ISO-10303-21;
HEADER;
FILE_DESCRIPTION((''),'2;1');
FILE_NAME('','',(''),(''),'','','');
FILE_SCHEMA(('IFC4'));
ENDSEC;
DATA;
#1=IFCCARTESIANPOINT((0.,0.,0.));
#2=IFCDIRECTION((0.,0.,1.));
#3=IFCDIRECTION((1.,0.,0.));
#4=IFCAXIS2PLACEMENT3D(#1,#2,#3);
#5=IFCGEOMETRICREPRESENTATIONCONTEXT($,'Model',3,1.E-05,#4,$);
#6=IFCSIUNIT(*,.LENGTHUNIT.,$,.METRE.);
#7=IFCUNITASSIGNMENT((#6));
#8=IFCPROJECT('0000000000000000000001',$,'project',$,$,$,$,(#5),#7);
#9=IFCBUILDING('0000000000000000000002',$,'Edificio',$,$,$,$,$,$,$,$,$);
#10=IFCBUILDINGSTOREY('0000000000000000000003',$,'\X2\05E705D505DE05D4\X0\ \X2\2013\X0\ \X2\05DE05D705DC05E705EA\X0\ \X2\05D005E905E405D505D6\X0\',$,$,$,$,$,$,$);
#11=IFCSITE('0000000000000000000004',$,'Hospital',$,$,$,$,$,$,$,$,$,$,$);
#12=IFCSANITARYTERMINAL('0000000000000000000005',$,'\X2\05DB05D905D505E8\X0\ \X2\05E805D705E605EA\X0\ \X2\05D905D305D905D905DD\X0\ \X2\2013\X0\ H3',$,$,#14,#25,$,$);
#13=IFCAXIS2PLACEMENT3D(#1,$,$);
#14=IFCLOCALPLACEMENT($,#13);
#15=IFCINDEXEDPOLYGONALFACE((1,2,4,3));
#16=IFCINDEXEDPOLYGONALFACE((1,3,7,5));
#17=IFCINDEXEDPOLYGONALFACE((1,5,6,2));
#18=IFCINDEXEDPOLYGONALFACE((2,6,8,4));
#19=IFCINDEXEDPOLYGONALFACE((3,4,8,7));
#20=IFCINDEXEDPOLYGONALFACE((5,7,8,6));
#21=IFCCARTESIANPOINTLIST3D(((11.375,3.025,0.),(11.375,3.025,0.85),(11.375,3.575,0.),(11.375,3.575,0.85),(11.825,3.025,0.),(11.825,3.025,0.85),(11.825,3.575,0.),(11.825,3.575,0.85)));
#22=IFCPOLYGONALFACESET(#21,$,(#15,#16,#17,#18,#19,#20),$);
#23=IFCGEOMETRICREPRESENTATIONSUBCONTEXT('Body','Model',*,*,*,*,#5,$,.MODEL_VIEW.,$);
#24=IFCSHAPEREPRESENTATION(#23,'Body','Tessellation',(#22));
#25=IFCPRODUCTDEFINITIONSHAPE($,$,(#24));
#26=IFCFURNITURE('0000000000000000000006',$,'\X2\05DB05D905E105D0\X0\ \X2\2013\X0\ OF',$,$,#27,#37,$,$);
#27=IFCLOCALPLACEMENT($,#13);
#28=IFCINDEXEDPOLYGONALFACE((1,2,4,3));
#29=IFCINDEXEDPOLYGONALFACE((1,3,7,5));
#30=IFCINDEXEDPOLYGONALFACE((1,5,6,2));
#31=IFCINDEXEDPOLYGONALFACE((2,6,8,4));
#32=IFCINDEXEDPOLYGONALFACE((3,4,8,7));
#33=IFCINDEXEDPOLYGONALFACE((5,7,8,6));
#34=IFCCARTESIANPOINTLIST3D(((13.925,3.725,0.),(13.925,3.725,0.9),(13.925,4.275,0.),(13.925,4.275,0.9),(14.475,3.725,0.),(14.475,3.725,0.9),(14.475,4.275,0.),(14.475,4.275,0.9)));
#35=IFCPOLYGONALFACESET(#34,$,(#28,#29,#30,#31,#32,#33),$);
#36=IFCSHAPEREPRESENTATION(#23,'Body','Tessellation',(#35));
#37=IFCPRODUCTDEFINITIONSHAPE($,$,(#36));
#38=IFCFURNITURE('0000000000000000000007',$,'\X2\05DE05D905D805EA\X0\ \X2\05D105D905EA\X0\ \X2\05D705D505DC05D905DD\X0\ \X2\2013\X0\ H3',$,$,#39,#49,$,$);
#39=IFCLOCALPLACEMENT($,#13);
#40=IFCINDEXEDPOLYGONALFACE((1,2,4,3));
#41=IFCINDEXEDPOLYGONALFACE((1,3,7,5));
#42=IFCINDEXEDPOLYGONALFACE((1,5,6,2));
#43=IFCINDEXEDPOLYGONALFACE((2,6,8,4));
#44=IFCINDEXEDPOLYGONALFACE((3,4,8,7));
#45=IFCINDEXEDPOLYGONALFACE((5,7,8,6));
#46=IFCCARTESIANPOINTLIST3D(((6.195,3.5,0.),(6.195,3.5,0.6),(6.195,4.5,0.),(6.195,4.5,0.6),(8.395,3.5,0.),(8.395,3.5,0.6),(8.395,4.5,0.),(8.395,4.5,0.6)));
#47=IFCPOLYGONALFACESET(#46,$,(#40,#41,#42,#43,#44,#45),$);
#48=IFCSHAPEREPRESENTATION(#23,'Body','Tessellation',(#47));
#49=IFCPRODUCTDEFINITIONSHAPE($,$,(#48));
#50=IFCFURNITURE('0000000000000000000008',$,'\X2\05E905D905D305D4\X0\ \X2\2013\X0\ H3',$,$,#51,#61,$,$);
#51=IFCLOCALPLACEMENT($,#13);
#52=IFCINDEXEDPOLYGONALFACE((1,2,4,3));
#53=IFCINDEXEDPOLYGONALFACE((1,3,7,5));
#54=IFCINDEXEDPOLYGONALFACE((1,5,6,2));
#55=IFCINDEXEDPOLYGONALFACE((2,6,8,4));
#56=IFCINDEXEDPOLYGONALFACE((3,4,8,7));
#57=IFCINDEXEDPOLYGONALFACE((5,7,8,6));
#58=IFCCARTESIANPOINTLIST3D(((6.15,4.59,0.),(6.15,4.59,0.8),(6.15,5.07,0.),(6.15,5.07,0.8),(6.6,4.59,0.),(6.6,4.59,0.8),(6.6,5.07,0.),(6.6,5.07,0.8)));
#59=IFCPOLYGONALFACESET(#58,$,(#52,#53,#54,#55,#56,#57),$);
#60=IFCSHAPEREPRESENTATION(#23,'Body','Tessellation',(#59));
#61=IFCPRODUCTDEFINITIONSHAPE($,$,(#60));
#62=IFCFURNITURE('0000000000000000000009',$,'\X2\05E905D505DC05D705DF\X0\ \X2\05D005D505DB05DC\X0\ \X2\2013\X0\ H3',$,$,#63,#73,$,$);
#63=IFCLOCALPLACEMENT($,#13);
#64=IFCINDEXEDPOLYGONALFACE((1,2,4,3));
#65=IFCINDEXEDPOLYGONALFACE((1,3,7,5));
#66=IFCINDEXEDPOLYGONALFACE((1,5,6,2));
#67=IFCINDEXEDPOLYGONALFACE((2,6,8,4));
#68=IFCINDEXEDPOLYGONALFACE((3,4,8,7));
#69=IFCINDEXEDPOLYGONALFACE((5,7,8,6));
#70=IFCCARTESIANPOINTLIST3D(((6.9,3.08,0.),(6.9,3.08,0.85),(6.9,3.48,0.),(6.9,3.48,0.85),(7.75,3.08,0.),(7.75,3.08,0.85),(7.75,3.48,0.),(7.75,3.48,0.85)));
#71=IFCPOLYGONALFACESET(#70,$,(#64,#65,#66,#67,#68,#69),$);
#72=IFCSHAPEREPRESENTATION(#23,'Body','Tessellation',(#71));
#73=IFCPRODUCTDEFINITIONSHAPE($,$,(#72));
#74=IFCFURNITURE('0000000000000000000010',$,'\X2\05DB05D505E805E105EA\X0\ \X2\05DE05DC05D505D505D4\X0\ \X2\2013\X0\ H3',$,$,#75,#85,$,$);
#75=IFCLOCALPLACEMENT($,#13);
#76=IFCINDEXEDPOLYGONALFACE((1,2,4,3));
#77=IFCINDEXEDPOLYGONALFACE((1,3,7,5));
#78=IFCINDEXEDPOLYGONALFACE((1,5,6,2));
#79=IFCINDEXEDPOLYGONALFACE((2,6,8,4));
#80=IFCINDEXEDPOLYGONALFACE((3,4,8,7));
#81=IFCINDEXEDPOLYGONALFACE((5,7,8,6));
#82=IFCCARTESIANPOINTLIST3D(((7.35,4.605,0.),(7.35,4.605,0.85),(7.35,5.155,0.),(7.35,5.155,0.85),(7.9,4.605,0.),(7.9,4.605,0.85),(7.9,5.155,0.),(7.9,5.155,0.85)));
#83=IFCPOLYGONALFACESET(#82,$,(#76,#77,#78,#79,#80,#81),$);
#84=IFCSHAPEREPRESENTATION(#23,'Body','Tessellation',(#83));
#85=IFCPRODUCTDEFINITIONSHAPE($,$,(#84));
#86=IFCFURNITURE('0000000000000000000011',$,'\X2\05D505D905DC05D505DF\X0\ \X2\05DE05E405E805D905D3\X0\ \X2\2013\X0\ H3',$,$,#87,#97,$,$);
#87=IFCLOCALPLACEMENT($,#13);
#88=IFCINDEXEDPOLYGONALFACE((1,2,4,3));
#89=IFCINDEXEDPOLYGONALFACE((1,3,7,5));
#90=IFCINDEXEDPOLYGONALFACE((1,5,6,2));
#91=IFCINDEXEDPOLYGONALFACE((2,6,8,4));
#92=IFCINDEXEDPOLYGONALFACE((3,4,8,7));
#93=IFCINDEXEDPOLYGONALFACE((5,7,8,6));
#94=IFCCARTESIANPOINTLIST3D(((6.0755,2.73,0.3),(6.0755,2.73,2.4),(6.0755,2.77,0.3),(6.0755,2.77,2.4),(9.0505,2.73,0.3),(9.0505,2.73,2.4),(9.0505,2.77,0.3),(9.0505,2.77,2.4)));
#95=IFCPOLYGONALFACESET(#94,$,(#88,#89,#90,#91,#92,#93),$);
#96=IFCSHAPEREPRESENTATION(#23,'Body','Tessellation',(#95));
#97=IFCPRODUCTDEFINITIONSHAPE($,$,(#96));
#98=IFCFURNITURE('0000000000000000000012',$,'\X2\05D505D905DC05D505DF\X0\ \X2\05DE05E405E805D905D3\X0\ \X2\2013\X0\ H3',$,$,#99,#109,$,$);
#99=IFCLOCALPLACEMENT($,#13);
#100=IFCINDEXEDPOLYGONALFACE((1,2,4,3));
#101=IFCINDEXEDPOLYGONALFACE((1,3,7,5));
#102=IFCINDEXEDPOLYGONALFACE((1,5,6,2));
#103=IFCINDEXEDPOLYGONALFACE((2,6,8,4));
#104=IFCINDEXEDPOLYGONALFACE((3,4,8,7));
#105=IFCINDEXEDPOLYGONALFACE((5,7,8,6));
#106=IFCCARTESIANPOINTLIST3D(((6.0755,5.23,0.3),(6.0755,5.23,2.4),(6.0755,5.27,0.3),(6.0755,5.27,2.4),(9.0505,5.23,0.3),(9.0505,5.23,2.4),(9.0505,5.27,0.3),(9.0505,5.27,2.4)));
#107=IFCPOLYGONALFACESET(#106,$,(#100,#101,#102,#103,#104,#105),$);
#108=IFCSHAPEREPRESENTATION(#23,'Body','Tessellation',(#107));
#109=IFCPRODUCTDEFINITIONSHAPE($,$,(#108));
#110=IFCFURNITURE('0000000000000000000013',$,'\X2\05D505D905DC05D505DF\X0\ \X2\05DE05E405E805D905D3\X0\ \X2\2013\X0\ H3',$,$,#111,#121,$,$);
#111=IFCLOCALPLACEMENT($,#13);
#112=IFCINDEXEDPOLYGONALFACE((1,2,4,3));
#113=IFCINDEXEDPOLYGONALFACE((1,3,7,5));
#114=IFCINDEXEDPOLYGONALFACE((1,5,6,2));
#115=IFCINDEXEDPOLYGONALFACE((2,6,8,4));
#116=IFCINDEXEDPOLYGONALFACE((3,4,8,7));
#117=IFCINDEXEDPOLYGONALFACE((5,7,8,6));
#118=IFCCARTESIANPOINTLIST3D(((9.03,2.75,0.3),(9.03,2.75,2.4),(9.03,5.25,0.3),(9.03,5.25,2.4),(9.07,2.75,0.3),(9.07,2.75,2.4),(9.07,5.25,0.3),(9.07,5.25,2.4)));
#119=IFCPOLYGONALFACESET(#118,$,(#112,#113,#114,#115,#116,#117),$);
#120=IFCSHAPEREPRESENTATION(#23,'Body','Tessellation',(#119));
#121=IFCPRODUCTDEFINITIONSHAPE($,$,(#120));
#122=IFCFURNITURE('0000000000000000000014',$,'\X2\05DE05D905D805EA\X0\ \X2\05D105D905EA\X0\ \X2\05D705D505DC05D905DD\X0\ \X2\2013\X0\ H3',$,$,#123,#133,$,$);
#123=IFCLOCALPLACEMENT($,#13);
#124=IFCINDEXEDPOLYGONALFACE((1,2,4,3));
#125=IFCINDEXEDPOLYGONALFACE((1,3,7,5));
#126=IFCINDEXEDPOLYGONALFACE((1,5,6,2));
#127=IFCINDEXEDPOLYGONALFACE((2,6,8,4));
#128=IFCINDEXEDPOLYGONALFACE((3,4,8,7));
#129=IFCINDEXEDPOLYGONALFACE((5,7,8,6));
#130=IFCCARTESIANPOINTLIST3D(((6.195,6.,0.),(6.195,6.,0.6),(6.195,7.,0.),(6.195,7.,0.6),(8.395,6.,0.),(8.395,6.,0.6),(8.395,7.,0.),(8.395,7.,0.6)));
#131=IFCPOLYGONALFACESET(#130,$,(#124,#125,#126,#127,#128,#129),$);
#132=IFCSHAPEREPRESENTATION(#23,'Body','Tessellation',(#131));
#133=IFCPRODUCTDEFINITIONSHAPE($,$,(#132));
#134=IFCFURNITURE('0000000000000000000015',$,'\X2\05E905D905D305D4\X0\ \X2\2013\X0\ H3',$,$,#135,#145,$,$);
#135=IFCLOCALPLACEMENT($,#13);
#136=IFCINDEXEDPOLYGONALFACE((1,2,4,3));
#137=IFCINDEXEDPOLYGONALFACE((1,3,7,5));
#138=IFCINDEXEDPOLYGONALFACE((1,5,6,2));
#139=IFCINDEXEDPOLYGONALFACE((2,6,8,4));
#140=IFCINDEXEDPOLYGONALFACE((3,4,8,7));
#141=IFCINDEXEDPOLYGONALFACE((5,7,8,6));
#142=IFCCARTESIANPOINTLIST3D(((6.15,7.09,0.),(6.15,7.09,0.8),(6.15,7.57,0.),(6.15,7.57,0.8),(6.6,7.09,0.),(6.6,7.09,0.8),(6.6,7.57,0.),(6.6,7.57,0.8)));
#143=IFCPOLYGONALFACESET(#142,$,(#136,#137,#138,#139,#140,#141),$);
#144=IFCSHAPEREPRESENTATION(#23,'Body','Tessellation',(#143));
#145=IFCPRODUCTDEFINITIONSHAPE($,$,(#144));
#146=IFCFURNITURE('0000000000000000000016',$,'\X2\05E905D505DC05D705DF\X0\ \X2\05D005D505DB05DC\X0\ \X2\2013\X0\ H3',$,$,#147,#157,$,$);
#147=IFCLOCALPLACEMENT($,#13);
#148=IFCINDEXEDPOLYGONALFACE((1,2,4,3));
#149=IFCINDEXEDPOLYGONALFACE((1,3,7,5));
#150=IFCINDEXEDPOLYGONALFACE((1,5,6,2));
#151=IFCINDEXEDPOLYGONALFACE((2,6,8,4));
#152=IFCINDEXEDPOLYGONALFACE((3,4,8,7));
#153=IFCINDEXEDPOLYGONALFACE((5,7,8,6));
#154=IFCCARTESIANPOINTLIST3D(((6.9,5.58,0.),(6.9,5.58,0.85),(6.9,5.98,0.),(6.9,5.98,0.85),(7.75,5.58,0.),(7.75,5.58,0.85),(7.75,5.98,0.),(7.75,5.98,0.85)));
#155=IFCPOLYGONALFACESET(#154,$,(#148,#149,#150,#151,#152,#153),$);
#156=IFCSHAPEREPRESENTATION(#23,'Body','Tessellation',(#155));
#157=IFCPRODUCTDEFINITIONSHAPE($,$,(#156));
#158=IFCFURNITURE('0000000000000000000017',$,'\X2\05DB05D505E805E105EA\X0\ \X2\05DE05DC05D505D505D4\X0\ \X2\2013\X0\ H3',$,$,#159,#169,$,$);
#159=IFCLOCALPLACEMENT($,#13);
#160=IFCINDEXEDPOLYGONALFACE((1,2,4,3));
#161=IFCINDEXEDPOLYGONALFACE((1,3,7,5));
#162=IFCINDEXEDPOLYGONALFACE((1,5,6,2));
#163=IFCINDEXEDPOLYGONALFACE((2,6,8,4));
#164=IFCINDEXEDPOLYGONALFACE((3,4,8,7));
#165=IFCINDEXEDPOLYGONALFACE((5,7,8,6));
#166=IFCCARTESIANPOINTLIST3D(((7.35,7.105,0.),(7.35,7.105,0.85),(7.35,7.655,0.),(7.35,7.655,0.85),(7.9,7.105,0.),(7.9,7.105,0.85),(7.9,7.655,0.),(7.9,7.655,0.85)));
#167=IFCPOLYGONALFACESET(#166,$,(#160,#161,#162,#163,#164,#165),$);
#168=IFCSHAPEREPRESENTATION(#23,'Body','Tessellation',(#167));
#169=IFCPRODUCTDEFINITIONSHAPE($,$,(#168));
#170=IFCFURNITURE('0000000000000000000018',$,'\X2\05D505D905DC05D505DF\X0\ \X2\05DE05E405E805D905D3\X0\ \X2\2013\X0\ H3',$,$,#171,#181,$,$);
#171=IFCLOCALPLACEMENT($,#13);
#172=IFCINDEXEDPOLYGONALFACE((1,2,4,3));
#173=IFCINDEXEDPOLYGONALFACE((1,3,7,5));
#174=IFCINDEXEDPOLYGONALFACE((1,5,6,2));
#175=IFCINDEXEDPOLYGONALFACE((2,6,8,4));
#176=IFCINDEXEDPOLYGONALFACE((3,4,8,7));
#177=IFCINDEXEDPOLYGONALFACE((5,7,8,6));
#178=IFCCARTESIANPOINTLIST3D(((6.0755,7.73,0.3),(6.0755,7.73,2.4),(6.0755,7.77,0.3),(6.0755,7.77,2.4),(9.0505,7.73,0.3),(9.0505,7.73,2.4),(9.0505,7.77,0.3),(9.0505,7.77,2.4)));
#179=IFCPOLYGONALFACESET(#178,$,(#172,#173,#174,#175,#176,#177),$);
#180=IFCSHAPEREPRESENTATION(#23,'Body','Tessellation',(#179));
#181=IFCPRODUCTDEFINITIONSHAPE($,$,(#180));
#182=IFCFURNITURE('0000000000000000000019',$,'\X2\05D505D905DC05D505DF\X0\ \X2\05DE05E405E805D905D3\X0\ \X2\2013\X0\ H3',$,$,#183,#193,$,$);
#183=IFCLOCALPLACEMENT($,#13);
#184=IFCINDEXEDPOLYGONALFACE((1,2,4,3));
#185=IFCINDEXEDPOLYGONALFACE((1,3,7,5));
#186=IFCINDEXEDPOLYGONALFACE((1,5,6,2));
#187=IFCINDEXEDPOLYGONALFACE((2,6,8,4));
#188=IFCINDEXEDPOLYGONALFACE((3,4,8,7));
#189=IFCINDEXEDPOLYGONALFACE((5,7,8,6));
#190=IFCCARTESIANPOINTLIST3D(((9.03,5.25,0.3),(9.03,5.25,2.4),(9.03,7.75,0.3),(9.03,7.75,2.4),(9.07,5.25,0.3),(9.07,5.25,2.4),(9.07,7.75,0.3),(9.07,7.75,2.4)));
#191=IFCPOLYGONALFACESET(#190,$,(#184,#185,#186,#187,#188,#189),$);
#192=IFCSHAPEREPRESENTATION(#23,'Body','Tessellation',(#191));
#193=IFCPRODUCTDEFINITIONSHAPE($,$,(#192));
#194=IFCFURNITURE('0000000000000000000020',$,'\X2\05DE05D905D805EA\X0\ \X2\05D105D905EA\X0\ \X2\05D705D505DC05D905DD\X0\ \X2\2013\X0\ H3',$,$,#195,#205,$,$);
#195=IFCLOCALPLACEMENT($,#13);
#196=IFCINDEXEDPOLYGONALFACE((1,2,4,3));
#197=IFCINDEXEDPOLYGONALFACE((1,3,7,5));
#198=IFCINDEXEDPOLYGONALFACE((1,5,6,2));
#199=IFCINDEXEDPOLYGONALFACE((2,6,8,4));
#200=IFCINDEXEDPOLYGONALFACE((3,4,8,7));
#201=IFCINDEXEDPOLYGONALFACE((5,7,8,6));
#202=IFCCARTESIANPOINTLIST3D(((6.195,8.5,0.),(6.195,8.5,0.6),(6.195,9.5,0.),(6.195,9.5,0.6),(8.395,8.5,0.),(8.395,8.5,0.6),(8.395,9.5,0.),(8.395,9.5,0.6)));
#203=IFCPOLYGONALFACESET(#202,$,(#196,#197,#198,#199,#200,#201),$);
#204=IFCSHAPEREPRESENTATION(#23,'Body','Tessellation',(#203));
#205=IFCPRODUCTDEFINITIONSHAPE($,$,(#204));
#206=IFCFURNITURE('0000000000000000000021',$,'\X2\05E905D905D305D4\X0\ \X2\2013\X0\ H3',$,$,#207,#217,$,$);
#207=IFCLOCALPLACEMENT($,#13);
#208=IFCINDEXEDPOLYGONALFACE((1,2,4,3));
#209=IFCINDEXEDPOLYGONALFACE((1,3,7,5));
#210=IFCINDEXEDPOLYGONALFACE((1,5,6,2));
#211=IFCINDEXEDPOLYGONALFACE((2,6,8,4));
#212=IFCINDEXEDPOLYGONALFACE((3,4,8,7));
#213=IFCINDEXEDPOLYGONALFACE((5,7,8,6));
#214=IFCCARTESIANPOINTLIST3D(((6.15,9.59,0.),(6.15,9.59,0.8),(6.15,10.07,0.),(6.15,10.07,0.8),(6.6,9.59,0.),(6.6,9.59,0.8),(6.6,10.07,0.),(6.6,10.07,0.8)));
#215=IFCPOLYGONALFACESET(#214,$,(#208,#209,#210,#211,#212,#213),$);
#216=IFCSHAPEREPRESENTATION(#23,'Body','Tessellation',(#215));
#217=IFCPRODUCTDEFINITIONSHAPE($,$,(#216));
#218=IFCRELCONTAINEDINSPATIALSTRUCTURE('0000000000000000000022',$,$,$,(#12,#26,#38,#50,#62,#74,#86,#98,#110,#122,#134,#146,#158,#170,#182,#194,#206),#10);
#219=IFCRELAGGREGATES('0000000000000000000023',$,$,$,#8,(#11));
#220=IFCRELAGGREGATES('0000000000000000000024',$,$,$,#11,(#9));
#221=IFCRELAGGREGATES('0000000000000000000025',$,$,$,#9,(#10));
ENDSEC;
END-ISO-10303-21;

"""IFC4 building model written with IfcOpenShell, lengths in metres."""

from ifc_helpers import new_model, si_unit, frame, origin_with_axes, context, subcontext, project, spatial, line, indexed_curve, outline, extrude, element, save


model = new_model("IFC4")

# Units and contexts
model_context = context("Model", 3, precision=1e-05, world=origin_with_axes())
body_context = subcontext(model_context, "Body", "Model", "MODEL_VIEW")
ifc_project = project(units=[si_unit("LENGTHUNIT", "METRE")], contexts=[model_context])

# Site, building, storey
site = spatial("IfcSite", under=ifc_project, Name="Hospital")
building = spatial("IfcBuilding", under=site, Name="Edificio")
storey = spatial("IfcBuildingStorey", under=building, Name="קומה – מחלקת אשפוז")

# Sanitary terminal
element("IfcSanitaryTerminal", 1, inside=storey, Name="כיור רחצת ידיים – H3", context=body_context, shape_type="SweptSolid", body=[
    extrude(outline(indexed_curve([(0.0, 0.0), (0.45, 0.0), (0.45, 0.55), (0.0, 0.55)], segments=[line(1, 2, 3, 4, 1)])), frame((11.375, 3.025, 0.0), z_axis=(0.0, 0.0, 1.0), x_axis=(1.0, 0.0, 0.0)), (0.0, 0.0, 1.0), 0.85),
])

# Furniture
element("IfcFurniture", 2, inside=storey, Name="כיסא – OF", context=body_context, shape_type="SweptSolid", body=[
    extrude(outline(indexed_curve([(0.0, 0.0), (0.55, 0.0), (0.55, 0.55), (0.0, 0.55)], segments=[line(1, 2, 3, 4, 1)])), frame((13.925, 3.725, 0.0), z_axis=(0.0, 0.0, 1.0), x_axis=(1.0, 0.0, 0.0)), (0.0, 0.0, 1.0), 0.9),
])
element("IfcFurniture", 3, inside=storey, Name="מיטת בית חולים – H3", context=body_context, shape_type="SweptSolid", body=[
    extrude(outline(indexed_curve([(0.0, 0.0), (2.2, 0.0), (2.2, 1.0), (0.0, 1.0)], segments=[line(1, 2, 3, 4, 1)])), frame((6.195, 3.5, 0.0), z_axis=(0.0, 0.0, 1.0), x_axis=(1.0, 0.0, 0.0)), (0.0, 0.0, 1.0), 0.6),
])
element("IfcFurniture", 4, inside=storey, Name="שידה – H3", context=body_context, shape_type="SweptSolid", body=[
    extrude(outline(indexed_curve([(0.0, 0.0), (0.45, 0.0), (0.45, 0.48), (0.0, 0.48)], segments=[line(1, 2, 3, 4, 1)])), frame((6.15, 4.59, 0.0), z_axis=(0.0, 0.0, 1.0), x_axis=(1.0, 0.0, 0.0)), (0.0, 0.0, 1.0), 0.8),
])
element("IfcFurniture", 5, inside=storey, Name="שולחן אוכל – H3", context=body_context, shape_type="SweptSolid", body=[
    extrude(outline(indexed_curve([(0.0, 0.0), (0.85, 0.0), (0.85, 0.4), (0.0, 0.4)], segments=[line(1, 2, 3, 4, 1)])), frame((6.9, 3.08, 0.0), z_axis=(0.0, 0.0, 1.0), x_axis=(1.0, 0.0, 0.0)), (0.0, 0.0, 1.0), 0.85),
])
element("IfcFurniture", 6, inside=storey, Name="כורסת מלווה – H3", context=body_context, shape_type="SweptSolid", body=[
    extrude(outline(indexed_curve([(0.0, 0.0), (0.55, 0.0), (0.55, 0.55), (0.0, 0.55)], segments=[line(1, 2, 3, 4, 1)])), frame((7.35, 4.605, 0.0), z_axis=(0.0, 0.0, 1.0), x_axis=(1.0, 0.0, 0.0)), (0.0, 0.0, 1.0), 0.85),
])
element("IfcFurniture", 7, inside=storey, Name="וילון מפריד – H3", context=body_context, shape_type="SweptSolid", body=[
    extrude(outline(indexed_curve([(0.0, 0.0), (2.975, 0.0), (2.975, 0.04), (0.0, 0.04)], segments=[line(1, 2, 3, 4, 1)])), frame((6.0755, 2.73, 0.3), z_axis=(0.0, 0.0, 1.0), x_axis=(1.0, 0.0, 0.0)), (0.0, 0.0, 1.0), 2.1),
])
element("IfcFurniture", 8, inside=storey, Name="וילון מפריד – H3", context=body_context, shape_type="SweptSolid", body=[
    extrude(outline(indexed_curve([(0.0, 0.0), (2.975, 0.0), (2.975, 0.04), (0.0, 0.04)], segments=[line(1, 2, 3, 4, 1)])), frame((6.0755, 5.23, 0.3), z_axis=(0.0, 0.0, 1.0), x_axis=(1.0, 0.0, 0.0)), (0.0, 0.0, 1.0), 2.1),
])
element("IfcFurniture", 9, inside=storey, Name="וילון מפריד – H3", context=body_context, shape_type="SweptSolid", body=[
    extrude(outline(indexed_curve([(0.0, 0.0), (0.04, 0.0), (0.04, 2.5), (0.0, 2.5)], segments=[line(1, 2, 3, 4, 1)])), frame((9.03, 2.75, 0.3), z_axis=(0.0, 0.0, 1.0), x_axis=(1.0, 0.0, 0.0)), (0.0, 0.0, 1.0), 2.1),
])
element("IfcFurniture", 10, inside=storey, Name="מיטת בית חולים – H3", context=body_context, shape_type="SweptSolid", body=[
    extrude(outline(indexed_curve([(0.0, 0.0), (2.2, 0.0), (2.2, 1.0), (0.0, 1.0)], segments=[line(1, 2, 3, 4, 1)])), frame((6.195, 6.0, 0.0), z_axis=(0.0, 0.0, 1.0), x_axis=(1.0, 0.0, 0.0)), (0.0, 0.0, 1.0), 0.6),
])
element("IfcFurniture", 11, inside=storey, Name="שידה – H3", context=body_context, shape_type="SweptSolid", body=[
    extrude(outline(indexed_curve([(0.0, 0.0), (0.45, 0.0), (0.45, 0.48), (0.0, 0.48)], segments=[line(1, 2, 3, 4, 1)])), frame((6.15, 7.09, 0.0), z_axis=(0.0, 0.0, 1.0), x_axis=(1.0, 0.0, 0.0)), (0.0, 0.0, 1.0), 0.8),
])
element("IfcFurniture", 12, inside=storey, Name="שולחן אוכל – H3", context=body_context, shape_type="SweptSolid", body=[
    extrude(outline(indexed_curve([(0.0, 0.0), (0.85, 0.0), (0.85, 0.4), (0.0, 0.4)], segments=[line(1, 2, 3, 4, 1)])), frame((6.9, 5.58, 0.0), z_axis=(0.0, 0.0, 1.0), x_axis=(1.0, 0.0, 0.0)), (0.0, 0.0, 1.0), 0.85),
])
element("IfcFurniture", 13, inside=storey, Name="כורסת מלווה – H3", context=body_context, shape_type="SweptSolid", body=[
    extrude(outline(indexed_curve([(0.0, 0.0), (0.55, 0.0), (0.55, 0.55), (0.0, 0.55)], segments=[line(1, 2, 3, 4, 1)])), frame((7.35, 7.105, 0.0), z_axis=(0.0, 0.0, 1.0), x_axis=(1.0, 0.0, 0.0)), (0.0, 0.0, 1.0), 0.85),
])
element("IfcFurniture", 14, inside=storey, Name="וילון מפריד – H3", context=body_context, shape_type="SweptSolid", body=[
    extrude(outline(indexed_curve([(0.0, 0.0), (2.975, 0.0), (2.975, 0.04), (0.0, 0.04)], segments=[line(1, 2, 3, 4, 1)])), frame((6.0755, 7.73, 0.3), z_axis=(0.0, 0.0, 1.0), x_axis=(1.0, 0.0, 0.0)), (0.0, 0.0, 1.0), 2.1),
])
element("IfcFurniture", 15, inside=storey, Name="וילון מפריד – H3", context=body_context, shape_type="SweptSolid", body=[
    extrude(outline(indexed_curve([(0.0, 0.0), (0.04, 0.0), (0.04, 2.5), (0.0, 2.5)], segments=[line(1, 2, 3, 4, 1)])), frame((9.03, 5.25, 0.3), z_axis=(0.0, 0.0, 1.0), x_axis=(1.0, 0.0, 0.0)), (0.0, 0.0, 1.0), 2.1),
])
element("IfcFurniture", 16, inside=storey, Name="מיטת בית חולים – H3", context=body_context, shape_type="SweptSolid", body=[
    extrude(outline(indexed_curve([(0.0, 0.0), (2.2, 0.0), (2.2, 1.0), (0.0, 1.0)], segments=[line(1, 2, 3, 4, 1)])), frame((6.195, 8.5, 0.0), z_axis=(0.0, 0.0, 1.0), x_axis=(1.0, 0.0, 0.0)), (0.0, 0.0, 1.0), 0.6),
])
element("IfcFurniture", 17, inside=storey, Name="שידה – H3", context=body_context, shape_type="SweptSolid", body=[
    extrude(outline(indexed_curve([(0.0, 0.0), (0.45, 0.0), (0.45, 0.48), (0.0, 0.48)], segments=[line(1, 2, 3, 4, 1)])), frame((6.15, 9.59, 0.0), z_axis=(0.0, 0.0, 1.0), x_axis=(1.0, 0.0, 0.0)), (0.0, 0.0, 1.0), 0.8),
])

save(model, "model.ifc")
